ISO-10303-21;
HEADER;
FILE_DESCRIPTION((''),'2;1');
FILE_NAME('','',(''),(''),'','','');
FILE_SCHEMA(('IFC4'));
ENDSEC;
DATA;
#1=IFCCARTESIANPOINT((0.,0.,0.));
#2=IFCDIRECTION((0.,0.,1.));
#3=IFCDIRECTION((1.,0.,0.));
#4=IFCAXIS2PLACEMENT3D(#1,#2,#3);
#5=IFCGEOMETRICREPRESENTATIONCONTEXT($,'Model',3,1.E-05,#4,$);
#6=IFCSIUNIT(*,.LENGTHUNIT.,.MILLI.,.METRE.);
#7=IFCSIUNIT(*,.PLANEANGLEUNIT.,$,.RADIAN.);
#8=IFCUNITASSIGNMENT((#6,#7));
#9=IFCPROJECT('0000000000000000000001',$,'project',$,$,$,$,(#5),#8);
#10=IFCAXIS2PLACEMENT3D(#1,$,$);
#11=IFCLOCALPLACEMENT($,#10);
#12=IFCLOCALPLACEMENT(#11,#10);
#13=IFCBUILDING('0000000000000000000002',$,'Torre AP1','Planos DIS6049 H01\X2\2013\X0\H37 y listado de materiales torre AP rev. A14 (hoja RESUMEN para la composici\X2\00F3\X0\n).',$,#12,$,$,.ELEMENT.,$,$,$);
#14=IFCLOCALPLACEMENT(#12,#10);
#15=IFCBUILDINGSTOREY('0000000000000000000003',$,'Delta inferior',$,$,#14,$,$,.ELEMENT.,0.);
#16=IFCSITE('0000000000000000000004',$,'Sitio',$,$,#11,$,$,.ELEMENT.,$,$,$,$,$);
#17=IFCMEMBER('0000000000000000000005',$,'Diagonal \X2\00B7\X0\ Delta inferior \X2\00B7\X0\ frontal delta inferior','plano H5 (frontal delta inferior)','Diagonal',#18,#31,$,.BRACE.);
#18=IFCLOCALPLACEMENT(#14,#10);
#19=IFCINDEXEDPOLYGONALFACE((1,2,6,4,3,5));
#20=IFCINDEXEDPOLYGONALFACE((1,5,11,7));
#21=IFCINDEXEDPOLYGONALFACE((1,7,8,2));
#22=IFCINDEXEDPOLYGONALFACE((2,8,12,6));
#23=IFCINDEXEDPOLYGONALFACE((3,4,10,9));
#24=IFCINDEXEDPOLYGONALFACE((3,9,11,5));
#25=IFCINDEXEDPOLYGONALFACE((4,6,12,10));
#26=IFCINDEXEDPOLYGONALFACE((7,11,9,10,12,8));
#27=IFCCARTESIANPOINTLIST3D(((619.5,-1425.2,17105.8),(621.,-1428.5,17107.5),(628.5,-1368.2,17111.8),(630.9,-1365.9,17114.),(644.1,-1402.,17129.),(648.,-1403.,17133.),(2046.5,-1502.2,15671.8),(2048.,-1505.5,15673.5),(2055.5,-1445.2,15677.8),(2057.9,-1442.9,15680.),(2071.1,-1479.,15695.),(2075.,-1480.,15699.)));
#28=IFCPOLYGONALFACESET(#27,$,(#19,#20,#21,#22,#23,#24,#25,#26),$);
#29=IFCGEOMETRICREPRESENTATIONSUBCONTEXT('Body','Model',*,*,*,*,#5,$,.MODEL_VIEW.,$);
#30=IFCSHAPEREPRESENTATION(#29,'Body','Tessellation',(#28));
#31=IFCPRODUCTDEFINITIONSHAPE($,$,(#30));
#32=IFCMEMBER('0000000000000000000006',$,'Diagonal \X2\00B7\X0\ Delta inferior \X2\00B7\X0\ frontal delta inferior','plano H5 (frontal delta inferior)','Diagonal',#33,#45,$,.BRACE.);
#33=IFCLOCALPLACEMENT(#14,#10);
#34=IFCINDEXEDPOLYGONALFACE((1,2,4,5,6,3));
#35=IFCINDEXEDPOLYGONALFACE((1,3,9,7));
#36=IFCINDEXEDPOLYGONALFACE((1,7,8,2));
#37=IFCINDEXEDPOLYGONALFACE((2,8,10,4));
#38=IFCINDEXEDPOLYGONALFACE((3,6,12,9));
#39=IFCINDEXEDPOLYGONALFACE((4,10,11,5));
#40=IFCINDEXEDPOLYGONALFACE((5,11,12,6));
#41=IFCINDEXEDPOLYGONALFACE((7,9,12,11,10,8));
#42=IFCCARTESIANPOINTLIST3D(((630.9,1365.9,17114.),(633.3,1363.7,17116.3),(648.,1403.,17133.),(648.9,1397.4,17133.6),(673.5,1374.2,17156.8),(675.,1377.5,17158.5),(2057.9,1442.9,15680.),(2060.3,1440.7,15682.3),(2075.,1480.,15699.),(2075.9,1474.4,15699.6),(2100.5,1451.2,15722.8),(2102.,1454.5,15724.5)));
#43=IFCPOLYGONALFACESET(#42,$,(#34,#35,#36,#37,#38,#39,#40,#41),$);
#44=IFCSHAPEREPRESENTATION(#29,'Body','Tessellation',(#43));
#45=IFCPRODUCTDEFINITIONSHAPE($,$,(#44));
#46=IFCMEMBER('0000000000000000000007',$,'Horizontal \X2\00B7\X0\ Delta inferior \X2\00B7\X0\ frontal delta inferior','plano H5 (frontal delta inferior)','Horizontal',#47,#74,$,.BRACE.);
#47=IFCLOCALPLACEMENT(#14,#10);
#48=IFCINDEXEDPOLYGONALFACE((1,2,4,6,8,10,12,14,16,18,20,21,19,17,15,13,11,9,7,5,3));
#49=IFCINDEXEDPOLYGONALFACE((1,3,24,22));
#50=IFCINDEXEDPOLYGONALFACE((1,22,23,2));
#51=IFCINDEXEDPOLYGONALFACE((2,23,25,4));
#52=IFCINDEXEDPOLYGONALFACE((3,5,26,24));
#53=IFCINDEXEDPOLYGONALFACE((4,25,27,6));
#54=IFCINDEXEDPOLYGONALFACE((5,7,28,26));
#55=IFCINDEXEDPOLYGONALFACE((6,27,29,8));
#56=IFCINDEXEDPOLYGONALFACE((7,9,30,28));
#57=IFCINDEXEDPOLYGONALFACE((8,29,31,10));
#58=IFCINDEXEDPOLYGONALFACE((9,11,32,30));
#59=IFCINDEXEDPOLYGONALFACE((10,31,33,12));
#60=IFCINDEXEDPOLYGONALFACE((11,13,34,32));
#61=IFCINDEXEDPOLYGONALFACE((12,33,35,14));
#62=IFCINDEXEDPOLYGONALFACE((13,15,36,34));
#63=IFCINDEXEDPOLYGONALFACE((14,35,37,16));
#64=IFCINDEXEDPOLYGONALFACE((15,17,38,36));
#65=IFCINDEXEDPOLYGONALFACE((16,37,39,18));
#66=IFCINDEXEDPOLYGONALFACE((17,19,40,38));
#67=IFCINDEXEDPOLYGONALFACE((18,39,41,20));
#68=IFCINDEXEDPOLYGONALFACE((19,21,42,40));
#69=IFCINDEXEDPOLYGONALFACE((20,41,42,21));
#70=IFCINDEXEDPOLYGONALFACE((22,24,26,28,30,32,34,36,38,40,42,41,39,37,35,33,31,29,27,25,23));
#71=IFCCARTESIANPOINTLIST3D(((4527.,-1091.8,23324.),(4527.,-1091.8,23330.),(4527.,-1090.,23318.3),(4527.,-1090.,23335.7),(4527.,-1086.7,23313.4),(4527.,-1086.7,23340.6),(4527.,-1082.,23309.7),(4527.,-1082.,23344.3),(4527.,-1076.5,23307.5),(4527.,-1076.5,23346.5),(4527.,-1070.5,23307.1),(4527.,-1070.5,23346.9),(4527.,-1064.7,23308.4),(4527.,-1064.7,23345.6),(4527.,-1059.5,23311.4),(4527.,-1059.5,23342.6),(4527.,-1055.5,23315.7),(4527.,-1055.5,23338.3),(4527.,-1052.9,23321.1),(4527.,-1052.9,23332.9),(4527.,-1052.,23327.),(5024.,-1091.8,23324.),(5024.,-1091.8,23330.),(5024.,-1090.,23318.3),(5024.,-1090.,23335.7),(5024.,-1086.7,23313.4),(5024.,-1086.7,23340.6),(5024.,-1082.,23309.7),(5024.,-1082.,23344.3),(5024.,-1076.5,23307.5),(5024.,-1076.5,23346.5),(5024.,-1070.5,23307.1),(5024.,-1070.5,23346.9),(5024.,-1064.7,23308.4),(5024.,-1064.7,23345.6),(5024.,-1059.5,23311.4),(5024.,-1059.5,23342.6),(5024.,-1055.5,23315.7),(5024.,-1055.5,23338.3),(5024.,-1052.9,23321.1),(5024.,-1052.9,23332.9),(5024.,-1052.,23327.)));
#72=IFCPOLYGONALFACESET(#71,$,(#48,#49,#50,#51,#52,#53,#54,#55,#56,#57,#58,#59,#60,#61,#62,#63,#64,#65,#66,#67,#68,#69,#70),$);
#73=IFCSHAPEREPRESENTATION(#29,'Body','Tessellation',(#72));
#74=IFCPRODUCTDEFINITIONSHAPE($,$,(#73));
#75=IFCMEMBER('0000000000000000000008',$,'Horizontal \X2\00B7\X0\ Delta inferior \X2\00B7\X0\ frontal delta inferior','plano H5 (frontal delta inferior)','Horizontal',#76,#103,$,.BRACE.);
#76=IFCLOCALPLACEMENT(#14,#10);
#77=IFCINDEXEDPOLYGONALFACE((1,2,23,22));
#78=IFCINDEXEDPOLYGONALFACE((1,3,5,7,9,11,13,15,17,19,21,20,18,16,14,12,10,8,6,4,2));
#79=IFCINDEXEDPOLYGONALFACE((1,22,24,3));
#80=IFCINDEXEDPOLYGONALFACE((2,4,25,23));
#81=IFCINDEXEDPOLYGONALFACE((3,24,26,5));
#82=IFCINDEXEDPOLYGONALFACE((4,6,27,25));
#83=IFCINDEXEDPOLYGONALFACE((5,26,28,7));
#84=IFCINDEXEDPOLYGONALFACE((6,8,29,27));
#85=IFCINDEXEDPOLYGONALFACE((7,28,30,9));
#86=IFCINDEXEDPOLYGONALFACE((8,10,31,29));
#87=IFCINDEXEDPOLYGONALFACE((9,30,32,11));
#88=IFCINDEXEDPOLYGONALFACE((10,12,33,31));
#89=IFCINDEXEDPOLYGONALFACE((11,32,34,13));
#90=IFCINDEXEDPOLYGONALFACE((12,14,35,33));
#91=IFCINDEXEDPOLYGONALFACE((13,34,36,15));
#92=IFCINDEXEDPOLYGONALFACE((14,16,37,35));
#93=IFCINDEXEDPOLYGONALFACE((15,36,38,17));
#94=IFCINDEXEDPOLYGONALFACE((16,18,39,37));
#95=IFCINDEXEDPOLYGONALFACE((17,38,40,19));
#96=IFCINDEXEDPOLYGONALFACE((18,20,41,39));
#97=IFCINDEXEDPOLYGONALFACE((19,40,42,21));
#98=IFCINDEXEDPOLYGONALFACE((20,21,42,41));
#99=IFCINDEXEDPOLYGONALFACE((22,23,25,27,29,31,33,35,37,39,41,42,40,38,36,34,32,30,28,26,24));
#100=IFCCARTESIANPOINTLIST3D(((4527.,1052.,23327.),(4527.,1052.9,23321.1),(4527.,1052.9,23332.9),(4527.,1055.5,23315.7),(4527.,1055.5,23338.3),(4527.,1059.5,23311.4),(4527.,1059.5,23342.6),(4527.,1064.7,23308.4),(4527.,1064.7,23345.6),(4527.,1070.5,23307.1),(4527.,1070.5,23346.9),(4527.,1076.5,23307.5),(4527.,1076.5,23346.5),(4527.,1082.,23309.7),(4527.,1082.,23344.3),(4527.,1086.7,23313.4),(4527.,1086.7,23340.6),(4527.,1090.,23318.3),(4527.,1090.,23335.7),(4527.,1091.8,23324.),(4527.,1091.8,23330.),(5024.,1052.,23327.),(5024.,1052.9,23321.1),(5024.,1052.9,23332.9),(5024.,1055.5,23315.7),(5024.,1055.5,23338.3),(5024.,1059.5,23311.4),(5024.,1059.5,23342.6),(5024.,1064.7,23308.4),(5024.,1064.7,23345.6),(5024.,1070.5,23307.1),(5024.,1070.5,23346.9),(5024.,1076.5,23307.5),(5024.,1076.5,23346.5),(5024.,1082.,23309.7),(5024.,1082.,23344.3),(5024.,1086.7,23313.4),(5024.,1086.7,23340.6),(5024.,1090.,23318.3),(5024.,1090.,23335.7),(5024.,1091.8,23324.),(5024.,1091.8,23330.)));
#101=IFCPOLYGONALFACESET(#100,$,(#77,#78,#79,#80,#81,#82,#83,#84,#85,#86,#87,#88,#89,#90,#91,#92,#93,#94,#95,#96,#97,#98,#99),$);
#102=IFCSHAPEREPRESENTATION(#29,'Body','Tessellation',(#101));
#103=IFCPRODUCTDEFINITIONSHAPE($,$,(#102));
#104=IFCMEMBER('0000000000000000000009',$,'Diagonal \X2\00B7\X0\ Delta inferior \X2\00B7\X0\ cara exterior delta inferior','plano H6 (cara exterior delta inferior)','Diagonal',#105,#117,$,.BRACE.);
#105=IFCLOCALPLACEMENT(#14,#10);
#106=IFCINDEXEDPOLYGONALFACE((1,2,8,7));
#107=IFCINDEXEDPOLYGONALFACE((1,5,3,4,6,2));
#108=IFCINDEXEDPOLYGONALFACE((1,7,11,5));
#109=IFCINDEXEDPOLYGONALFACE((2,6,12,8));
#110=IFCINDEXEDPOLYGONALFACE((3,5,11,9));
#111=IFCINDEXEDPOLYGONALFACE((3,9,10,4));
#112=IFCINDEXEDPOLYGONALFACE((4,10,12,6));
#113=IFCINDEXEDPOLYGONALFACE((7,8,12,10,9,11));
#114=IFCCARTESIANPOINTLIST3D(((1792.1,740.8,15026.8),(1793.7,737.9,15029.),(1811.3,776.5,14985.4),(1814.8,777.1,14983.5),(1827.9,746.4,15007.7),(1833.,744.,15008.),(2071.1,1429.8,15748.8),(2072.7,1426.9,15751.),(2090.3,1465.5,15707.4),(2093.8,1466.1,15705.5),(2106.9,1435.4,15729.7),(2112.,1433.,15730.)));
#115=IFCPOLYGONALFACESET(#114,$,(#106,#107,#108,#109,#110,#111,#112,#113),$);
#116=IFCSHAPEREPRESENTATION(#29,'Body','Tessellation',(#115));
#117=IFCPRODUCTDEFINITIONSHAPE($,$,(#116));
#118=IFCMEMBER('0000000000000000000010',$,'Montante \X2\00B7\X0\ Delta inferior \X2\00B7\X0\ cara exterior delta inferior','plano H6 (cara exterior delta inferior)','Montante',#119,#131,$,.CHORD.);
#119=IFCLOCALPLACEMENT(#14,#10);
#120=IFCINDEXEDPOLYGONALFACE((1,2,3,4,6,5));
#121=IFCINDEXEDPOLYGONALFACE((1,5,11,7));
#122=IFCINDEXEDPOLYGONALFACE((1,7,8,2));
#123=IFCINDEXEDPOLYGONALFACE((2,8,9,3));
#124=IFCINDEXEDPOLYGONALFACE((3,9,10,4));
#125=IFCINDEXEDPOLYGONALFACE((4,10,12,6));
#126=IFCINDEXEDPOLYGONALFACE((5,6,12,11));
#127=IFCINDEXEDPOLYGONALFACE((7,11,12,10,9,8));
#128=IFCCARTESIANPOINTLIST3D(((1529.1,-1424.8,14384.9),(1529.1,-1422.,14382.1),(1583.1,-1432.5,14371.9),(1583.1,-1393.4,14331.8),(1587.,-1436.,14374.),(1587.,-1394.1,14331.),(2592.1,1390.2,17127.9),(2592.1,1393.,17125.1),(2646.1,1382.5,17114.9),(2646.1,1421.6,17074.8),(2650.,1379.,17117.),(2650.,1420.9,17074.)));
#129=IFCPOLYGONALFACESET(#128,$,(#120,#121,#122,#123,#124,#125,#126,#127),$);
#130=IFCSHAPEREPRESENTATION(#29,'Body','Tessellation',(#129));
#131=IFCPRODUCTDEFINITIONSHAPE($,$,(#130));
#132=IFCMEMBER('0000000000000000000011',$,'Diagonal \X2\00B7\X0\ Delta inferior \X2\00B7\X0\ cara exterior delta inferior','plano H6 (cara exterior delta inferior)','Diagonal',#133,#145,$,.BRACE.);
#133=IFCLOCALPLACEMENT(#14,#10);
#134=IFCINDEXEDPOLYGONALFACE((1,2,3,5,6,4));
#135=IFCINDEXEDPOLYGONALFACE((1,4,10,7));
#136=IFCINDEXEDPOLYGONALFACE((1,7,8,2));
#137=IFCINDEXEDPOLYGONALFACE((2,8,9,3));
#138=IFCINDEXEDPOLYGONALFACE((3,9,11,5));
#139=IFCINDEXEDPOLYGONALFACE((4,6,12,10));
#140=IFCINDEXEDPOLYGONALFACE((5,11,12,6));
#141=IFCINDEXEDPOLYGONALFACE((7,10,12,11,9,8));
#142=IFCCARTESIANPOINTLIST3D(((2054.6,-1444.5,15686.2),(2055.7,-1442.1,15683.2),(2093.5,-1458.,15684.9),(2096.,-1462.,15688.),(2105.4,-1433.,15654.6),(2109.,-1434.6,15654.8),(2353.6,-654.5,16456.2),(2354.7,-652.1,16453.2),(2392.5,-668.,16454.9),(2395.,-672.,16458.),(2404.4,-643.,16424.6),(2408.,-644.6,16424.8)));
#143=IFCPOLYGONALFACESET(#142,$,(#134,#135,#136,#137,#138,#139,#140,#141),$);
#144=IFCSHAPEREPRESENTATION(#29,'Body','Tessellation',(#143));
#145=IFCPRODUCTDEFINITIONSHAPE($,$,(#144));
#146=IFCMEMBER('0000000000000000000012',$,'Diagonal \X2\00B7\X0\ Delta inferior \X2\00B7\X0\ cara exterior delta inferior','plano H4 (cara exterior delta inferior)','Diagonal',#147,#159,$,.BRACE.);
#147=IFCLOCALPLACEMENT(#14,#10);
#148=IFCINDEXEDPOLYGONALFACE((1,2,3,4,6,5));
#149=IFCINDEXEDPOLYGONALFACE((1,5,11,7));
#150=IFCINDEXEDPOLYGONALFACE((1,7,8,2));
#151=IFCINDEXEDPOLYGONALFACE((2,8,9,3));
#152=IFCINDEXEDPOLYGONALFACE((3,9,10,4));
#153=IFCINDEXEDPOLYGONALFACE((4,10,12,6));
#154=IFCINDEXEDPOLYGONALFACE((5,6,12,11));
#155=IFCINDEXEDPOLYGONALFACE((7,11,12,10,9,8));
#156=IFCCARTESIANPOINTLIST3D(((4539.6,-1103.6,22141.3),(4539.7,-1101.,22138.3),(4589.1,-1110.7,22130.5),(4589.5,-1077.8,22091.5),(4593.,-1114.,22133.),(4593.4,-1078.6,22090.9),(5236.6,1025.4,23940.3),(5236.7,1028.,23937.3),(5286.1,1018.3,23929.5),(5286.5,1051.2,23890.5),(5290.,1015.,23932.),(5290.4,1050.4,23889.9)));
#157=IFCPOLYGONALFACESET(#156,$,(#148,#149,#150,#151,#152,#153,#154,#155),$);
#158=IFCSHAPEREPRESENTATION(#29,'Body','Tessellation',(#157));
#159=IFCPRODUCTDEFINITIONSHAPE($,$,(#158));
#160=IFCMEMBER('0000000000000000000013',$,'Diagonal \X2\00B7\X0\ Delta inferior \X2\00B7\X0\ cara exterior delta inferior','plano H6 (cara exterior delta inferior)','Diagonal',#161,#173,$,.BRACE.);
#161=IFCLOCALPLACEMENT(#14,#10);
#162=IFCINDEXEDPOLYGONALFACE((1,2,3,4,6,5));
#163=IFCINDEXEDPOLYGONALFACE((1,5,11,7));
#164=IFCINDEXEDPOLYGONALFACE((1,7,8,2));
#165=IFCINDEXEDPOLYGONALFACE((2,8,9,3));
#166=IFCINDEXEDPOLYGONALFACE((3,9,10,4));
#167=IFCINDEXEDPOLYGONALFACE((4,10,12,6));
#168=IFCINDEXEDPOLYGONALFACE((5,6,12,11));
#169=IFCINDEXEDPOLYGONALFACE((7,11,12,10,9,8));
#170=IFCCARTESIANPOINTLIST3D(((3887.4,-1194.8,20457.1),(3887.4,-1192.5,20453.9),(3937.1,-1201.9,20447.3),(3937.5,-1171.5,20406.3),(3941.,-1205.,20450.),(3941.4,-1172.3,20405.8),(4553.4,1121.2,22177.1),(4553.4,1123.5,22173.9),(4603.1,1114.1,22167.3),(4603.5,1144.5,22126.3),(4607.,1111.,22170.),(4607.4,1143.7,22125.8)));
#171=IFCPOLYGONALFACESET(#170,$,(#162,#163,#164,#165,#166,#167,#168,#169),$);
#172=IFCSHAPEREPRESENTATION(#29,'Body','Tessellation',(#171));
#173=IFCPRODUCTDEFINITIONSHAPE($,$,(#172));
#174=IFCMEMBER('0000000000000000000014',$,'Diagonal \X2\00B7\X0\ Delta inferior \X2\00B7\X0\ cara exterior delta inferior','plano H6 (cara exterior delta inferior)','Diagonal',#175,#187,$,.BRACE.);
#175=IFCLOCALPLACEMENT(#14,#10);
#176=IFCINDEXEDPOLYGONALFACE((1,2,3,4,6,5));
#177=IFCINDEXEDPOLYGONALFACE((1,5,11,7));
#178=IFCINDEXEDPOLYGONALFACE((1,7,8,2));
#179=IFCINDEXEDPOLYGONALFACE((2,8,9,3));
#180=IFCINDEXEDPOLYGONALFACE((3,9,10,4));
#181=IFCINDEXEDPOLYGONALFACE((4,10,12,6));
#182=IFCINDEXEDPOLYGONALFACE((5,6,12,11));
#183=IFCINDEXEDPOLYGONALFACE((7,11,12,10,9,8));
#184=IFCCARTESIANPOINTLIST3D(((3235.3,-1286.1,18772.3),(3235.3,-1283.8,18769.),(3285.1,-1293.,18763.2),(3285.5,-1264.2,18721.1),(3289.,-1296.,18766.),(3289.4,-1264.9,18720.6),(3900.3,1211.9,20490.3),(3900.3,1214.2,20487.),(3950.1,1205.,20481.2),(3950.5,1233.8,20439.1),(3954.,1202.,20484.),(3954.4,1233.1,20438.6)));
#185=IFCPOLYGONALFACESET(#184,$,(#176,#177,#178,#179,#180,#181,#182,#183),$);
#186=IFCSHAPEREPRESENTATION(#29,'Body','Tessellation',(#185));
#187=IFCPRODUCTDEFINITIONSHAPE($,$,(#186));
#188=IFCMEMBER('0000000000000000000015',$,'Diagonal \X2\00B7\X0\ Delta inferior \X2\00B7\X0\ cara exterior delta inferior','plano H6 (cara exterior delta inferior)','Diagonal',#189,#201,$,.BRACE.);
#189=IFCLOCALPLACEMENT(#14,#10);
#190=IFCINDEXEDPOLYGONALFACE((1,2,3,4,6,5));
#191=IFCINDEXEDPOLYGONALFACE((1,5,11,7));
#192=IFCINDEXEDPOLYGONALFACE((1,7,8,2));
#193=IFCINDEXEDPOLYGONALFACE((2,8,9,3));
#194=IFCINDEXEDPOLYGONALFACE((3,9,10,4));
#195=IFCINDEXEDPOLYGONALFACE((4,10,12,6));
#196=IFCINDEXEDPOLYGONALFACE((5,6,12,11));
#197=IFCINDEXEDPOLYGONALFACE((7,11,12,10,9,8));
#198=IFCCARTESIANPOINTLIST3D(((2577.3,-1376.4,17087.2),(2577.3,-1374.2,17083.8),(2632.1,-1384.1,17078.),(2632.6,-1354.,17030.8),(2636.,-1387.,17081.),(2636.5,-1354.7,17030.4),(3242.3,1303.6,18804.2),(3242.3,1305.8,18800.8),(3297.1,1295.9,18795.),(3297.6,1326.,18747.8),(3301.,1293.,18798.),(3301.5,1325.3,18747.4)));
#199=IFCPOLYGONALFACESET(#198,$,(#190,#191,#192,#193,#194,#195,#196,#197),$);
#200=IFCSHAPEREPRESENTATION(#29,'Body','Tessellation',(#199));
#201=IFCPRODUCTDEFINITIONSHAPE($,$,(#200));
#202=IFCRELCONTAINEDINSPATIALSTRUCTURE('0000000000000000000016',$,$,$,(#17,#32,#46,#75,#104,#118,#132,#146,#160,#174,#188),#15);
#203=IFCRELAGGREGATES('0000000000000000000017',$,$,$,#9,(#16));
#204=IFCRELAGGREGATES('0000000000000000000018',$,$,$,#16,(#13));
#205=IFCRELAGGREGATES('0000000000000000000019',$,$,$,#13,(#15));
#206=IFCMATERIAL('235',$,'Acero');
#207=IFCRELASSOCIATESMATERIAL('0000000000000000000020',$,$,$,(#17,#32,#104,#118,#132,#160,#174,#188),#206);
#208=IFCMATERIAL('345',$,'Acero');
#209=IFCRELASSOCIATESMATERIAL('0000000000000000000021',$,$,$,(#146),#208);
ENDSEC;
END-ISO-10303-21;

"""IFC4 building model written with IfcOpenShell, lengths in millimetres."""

from ifc_helpers import new_model, si_unit, frame, frame_2d, origin, origin_with_axes, place, context, subcontext, project, spatial, circle, l_section, extrude, material, element, save


model = new_model("IFC4")

# Units and contexts
model_context = context("Model", 3, precision=1e-05, world=origin_with_axes())
body_context = subcontext(model_context, "Body", "Model", "MODEL_VIEW")
ifc_project = project(units=[si_unit("LENGTHUNIT", "METRE", prefix="MILLI"), si_unit("PLANEANGLEUNIT", "RADIAN")], contexts=[model_context])

# Site, building, storey
site_placement = place(None, origin())
site = spatial("IfcSite", under=ifc_project, at=site_placement, Name="Sitio", CompositionType="ELEMENT")
building_placement = place(site_placement, origin())
building = spatial("IfcBuilding", under=site, at=building_placement, Name="Torre AP1", Description="Planos DIS6049 H01–H37 y listado de materiales torre AP rev. A14 (hoja RESUMEN para la composición).", CompositionType="ELEMENT")
storey_placement = place(building_placement, origin())
storey = spatial("IfcBuildingStorey", under=building, at=storey_placement, Name="Delta inferior", CompositionType="ELEMENT", Elevation=0.0)

# Members
ifc_material_1 = material(Name="235", Category="Acero")
for number, where, z_axis, x_axis, name in (
    (1, (2075.0, -1480.0, 15699.0), (-0.704864, 0.038034, 0.708322), (-0.379432, 0.82348, -0.421797), "Diagonal · Delta inferior · frontal delta inferior"),
    (2, (2075.0, 1480.0, 15699.0), (-0.704864, -0.038034, 0.708322), (-0.379432, -0.82348, -0.421797), "Diagonal · Delta inferior · frontal delta inferior"),
):
    element("IfcMember", number, at=place(storey_placement, frame(where, z_axis=z_axis, x_axis=x_axis)), inside=storey, material=ifc_material_1, Name=name, Description="plano H5 (frontal delta inferior)", ObjectType="Diagonal", PredefinedType="BRACE", context=body_context, shape_type="SweptSolid", body=[
        extrude(l_section(Depth=45.0, Width=45.0, Thickness=4.0, at=frame_2d((22.5, 22.5))), None, (0.0, 0.0, 1.0), 2024.5),
    ])
for number, where, z_axis, x_axis, name in (
    (3, (5024.0, -1072.0, 23327.0), (-1.0, 0.0, 0.0), (0.0, 1.0, 0.0), "Horizontal · Delta inferior · frontal delta inferior"),
    (4, (5024.0, 1072.0, 23327.0), (-1.0, 0.0, 0.0), (0.0, -1.0, 0.0), "Horizontal · Delta inferior · frontal delta inferior"),
):
    element("IfcMember", number, at=place(storey_placement, frame(where, z_axis=z_axis, x_axis=x_axis)), inside=storey, Name=name, Description="plano H5 (frontal delta inferior)", ObjectType="Horizontal", PredefinedType="BRACE", context=body_context, shape_type="SweptSolid", body=[
        extrude(circle(Radius=20.0), None, (0.0, 0.0, 1.0), 497.0),
    ])
member_1_placement = place(storey_placement, frame((2112.0, 1433.0, 15730.0), z_axis=(-0.269236, -0.664888, -0.696733), x_axis=(-0.873631, -0.135855, 0.46724)))
element("IfcMember", 5, at=member_1_placement, inside=storey, material=ifc_material_1, Name="Diagonal · Delta inferior · cara exterior delta inferior", Description="plano H6 (cara exterior delta inferior)", ObjectType="Diagonal", PredefinedType="BRACE", context=body_context, shape_type="SweptSolid", body=[
    extrude(l_section(Depth=45.0, Width=45.0, Thickness=4.0, at=frame_2d((22.5, 22.5))), None, (0.0, 0.0, 1.0), 1036.3),
])
member_2_placement = place(storey_placement, frame((2650.0, 1379.0, 17117.0), z_axis=(-0.261074, -0.691368, -0.673685), x_axis=(-0.965319, 0.186983, 0.182201)))
element("IfcMember", 6, at=member_2_placement, inside=storey, material=ifc_material_1, Name="Montante · Delta inferior · cara exterior delta inferior", Description="plano H6 (cara exterior delta inferior)", ObjectType="Montante", PredefinedType="CHORD", context=body_context, shape_type="SweptSolid", body=[
    extrude(l_section(Depth=60.0, Width=60.0, Thickness=4.0, at=frame_2d((30.0, 30.0))), None, (0.0, 0.0, 1.0), 4071.6),
])
member_3_placement = place(storey_placement, frame((2395.0, -672.0, 16458.0), z_axis=(-0.261597, -0.691176, -0.673678), x_axis=(-0.920687, 0.38817, -0.040739)))
element("IfcMember", 7, at=member_3_placement, inside=storey, material=ifc_material_1, Name="Diagonal · Delta inferior · cara exterior delta inferior", Description="plano H6 (cara exterior delta inferior)", ObjectType="Diagonal", PredefinedType="BRACE", context=body_context, shape_type="SweptSolid", body=[
    extrude(l_section(Depth=45.0, Width=45.0, Thickness=4.0, at=frame_2d((22.5, 22.5))), None, (0.0, 0.0, 1.0), 1143.0),
])
ifc_material_2 = material(Name="345", Category="Acero")
member_4_placement = place(storey_placement, frame((5290.0, 1015.0, 23932.0), z_axis=(-0.242593, -0.741005, -0.626147), x_axis=(-0.970107, 0.189587, 0.151492)))
element("IfcMember", 8, at=member_4_placement, inside=storey, material=ifc_material_2, Name="Diagonal · Delta inferior · cara exterior delta inferior", Description="plano H4 (cara exterior delta inferior)", ObjectType="Diagonal", PredefinedType="BRACE", context=body_context, shape_type="SweptSolid", body=[
    extrude(l_section(Depth=55.0, Width=55.0, Thickness=4.0, at=frame_2d((27.5, 27.5))), None, (0.0, 0.0, 1.0), 2873.1),
])
member_5_placement = place(storey_placement, frame((4607.0, 1111.0, 22170.0), z_axis=(-0.224946, -0.782244, -0.580941), x_axis=(-0.974349, 0.184591, 0.128724)))
element("IfcMember", 9, at=member_5_placement, inside=storey, material=ifc_material_1, Name="Diagonal · Delta inferior · cara exterior delta inferior", Description="plano H6 (cara exterior delta inferior)", ObjectType="Diagonal", PredefinedType="BRACE", context=body_context, shape_type="SweptSolid", body=[
    extrude(l_section(Depth=55.0, Width=55.0, Thickness=4.0, at=frame_2d((27.5, 27.5))), None, (0.0, 0.0, 1.0), 2960.7),
])
member_6_placement = place(storey_placement, frame((3954.0, 1202.0, 20484.0), z_axis=(-0.214252, -0.804812, -0.55351), x_axis=(-0.976751, 0.180783, 0.115217)))
element("IfcMember", 10, at=member_6_placement, inside=storey, material=ifc_material_1, Name="Diagonal · Delta inferior · cara exterior delta inferior", Description="plano H6 (cara exterior delta inferior)", ObjectType="Diagonal", PredefinedType="BRACE", context=body_context, shape_type="SweptSolid", body=[
    extrude(l_section(Depth=55.0, Width=55.0, Thickness=4.0, at=frame_2d((27.5, 27.5))), None, (0.0, 0.0, 1.0), 3103.8),
])
member_7_placement = place(storey_placement, frame((3301.0, 1293.0, 18798.0), z_axis=(-0.204517, -0.824217, -0.528052), x_axis=(-0.978826, 0.176893, 0.102997)))
element("IfcMember", 11, at=member_7_placement, inside=storey, material=ifc_material_1, Name="Diagonal · Delta inferior · cara exterior delta inferior", Description="plano H6 (cara exterior delta inferior)", ObjectType="Diagonal", PredefinedType="BRACE", context=body_context, shape_type="SweptSolid", body=[
    extrude(l_section(Depth=60.0, Width=60.0, Thickness=4.0, at=frame_2d((30.0, 30.0))), None, (0.0, 0.0, 1.0), 3251.6),
])

save(model, "model.ifc")
